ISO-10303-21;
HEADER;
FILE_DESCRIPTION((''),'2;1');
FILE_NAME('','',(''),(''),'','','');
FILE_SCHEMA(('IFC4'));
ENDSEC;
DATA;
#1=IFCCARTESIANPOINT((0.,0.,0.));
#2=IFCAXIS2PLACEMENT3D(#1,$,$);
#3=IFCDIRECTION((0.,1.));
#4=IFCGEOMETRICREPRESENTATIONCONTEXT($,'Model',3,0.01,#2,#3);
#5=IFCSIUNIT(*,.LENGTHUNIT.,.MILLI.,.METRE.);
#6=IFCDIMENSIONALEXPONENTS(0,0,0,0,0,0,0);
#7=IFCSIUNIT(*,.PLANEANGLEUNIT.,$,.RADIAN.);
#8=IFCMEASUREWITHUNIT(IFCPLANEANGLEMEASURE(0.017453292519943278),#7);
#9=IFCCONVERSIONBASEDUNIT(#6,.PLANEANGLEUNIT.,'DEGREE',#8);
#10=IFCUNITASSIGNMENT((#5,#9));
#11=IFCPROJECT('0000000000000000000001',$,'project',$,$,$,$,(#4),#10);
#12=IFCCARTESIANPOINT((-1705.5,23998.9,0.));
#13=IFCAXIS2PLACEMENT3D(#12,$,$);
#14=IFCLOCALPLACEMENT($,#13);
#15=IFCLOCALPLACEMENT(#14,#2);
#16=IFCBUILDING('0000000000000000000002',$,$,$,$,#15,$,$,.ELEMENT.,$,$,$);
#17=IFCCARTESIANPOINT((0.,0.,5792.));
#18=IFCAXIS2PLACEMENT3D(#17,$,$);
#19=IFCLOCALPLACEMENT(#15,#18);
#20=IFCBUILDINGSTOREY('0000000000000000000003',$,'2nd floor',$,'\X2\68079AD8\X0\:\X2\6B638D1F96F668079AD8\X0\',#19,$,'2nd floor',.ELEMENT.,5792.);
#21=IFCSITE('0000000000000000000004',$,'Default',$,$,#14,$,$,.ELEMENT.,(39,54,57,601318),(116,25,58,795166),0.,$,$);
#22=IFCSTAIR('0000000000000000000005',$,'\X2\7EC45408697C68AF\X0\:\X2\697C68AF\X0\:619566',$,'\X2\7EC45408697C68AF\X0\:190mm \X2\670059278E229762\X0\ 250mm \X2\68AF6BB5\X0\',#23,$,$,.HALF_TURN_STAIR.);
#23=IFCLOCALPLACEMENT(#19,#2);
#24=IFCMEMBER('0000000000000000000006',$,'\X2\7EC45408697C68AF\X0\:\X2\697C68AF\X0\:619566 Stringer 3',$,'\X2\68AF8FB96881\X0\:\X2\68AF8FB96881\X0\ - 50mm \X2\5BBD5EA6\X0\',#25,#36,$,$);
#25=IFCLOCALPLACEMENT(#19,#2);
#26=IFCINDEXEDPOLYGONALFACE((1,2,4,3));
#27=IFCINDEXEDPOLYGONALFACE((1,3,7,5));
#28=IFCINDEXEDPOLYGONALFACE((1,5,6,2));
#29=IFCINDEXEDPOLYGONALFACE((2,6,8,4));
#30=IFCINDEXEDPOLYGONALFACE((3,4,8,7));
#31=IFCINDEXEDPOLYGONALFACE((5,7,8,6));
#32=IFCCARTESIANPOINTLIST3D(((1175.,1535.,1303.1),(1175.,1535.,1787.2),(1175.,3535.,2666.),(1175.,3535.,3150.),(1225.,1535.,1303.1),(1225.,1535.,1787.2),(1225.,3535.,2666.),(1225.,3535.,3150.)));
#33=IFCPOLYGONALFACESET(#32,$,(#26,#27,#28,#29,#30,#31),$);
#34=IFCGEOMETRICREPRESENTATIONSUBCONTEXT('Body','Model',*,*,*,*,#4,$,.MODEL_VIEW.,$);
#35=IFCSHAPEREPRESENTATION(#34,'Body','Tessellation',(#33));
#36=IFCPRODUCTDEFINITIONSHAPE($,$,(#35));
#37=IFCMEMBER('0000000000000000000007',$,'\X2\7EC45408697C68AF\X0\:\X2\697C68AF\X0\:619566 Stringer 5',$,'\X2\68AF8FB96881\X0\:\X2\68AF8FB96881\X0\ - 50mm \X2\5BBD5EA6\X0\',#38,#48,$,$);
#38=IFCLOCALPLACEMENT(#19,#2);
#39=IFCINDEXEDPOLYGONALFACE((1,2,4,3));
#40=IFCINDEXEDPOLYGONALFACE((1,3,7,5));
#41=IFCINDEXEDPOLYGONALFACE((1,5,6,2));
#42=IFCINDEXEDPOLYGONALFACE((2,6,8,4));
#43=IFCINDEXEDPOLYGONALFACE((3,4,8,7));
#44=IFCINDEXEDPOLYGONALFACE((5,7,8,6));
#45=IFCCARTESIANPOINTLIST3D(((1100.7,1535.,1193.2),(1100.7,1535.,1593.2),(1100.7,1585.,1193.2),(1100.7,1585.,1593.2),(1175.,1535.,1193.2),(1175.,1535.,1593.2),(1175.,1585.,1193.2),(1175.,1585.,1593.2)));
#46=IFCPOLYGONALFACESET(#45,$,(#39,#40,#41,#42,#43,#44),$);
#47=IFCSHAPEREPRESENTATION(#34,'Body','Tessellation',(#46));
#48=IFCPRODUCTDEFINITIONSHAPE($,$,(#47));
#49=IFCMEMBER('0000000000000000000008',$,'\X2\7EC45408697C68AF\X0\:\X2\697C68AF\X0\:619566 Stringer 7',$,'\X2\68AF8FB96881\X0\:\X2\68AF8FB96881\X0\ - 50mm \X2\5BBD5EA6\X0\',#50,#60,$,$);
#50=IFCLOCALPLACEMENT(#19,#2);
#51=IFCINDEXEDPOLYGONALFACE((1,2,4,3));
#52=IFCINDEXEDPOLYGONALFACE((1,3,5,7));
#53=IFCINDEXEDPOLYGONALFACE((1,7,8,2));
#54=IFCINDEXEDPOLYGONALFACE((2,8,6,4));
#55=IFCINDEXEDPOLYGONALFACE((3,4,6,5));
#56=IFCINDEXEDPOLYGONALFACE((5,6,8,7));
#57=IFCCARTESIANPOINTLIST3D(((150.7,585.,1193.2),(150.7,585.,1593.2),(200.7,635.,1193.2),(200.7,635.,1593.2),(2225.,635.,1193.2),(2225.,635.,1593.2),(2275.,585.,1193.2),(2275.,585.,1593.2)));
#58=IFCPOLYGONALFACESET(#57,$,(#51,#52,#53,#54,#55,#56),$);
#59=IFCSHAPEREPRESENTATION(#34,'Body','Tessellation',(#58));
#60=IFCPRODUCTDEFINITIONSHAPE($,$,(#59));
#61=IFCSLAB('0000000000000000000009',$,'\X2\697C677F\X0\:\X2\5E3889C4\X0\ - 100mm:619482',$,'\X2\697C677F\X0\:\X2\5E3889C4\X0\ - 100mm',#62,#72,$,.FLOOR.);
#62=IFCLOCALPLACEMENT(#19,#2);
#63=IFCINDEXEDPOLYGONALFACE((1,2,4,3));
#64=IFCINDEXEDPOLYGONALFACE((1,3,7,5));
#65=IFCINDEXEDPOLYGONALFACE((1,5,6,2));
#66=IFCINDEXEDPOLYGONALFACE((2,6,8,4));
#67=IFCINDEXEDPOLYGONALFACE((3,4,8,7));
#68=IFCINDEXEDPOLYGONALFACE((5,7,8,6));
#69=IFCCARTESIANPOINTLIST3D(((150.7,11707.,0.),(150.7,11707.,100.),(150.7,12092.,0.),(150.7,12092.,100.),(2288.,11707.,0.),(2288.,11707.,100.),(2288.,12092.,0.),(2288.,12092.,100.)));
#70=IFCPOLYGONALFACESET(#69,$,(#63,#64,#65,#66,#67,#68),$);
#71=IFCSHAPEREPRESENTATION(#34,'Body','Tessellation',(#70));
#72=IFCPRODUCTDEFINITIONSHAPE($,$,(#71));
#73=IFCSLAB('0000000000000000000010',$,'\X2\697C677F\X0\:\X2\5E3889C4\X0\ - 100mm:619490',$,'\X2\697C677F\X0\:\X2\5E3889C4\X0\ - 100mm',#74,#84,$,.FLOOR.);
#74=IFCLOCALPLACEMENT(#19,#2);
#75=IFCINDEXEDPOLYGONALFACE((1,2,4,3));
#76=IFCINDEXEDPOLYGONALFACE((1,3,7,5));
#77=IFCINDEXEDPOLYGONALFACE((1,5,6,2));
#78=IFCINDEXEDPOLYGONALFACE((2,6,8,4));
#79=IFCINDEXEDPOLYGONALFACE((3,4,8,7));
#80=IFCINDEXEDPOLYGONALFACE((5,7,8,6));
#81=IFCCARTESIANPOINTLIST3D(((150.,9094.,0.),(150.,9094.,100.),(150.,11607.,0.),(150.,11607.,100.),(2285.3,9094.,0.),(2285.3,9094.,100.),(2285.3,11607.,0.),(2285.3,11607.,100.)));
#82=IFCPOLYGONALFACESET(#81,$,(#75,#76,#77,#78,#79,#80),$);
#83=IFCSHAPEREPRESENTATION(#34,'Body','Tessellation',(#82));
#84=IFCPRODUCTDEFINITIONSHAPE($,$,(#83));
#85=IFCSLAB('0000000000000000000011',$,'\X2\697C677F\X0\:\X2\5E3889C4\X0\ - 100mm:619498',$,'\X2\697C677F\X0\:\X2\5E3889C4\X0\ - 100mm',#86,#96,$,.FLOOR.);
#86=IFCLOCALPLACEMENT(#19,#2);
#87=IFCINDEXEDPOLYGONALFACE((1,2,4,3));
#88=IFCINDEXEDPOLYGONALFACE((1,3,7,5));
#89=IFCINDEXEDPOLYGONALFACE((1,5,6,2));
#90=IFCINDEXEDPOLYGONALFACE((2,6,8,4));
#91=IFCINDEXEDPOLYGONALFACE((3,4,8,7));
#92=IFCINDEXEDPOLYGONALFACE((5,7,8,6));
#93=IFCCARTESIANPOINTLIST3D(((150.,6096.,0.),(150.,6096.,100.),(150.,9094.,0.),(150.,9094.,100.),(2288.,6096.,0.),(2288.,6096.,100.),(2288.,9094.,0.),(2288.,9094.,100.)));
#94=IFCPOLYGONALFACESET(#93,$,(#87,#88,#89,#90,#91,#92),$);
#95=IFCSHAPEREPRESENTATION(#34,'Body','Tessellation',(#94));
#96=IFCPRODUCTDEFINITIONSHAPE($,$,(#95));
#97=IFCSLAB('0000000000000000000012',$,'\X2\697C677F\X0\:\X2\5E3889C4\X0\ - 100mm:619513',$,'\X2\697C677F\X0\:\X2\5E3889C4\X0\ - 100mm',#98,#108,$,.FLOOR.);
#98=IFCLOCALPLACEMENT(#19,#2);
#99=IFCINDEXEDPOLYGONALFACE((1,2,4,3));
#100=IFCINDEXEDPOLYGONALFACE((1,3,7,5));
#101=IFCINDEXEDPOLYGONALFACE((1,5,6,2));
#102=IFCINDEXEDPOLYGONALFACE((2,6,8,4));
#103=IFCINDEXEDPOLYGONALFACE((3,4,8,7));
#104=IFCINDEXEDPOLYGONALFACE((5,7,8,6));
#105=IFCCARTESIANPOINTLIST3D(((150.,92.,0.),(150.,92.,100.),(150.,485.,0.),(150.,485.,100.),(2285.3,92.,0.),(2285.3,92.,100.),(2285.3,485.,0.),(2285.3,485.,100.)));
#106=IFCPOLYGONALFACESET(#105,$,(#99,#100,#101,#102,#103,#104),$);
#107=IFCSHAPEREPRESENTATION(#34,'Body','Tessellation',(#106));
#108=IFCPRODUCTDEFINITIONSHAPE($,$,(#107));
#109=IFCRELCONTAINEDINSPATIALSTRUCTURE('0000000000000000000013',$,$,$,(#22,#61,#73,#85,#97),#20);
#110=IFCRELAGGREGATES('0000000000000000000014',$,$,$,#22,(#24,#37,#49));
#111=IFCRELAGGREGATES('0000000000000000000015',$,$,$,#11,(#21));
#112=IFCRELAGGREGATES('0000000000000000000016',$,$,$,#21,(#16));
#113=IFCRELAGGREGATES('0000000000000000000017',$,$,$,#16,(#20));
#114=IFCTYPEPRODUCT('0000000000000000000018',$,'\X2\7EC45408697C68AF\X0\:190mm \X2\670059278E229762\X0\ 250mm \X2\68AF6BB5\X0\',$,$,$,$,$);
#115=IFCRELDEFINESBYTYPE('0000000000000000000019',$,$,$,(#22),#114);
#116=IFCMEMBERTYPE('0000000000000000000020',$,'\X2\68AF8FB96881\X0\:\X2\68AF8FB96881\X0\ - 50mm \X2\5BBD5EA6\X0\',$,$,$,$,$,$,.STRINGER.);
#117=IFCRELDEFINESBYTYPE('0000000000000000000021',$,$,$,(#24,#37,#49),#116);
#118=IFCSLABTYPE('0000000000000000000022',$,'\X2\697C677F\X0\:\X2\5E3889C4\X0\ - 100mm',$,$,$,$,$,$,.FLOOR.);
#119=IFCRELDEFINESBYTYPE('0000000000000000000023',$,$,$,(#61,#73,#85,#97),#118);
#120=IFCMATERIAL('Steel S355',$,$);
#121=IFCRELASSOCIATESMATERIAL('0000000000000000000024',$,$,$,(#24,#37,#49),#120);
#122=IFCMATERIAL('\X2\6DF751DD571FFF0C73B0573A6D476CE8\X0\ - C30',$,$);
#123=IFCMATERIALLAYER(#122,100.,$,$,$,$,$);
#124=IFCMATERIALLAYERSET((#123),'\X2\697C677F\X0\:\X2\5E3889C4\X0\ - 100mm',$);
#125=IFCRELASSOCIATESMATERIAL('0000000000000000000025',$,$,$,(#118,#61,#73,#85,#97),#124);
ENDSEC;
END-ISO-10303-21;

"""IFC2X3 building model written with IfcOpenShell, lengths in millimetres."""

from ifc_helpers import new_model, entity, si_unit, converted_unit, direction, frame, frame_2d, origin, origin_2d_with_axis, place, context, subcontext, project, spatial, polyline, rectangle, outline, extrude, material, layer, layer_set, layer_usage, type_object, element, aggregate, save


model = new_model("IFC2X3")

# Units and contexts
model_context = context("Model", 3, precision=0.01, world=origin(), true_north=direction((0.0, 1.0)))
body_context = subcontext(model_context, "Body", "Model", "MODEL_VIEW")
ifc_project = project(units=[si_unit("LENGTHUNIT", "METRE", prefix="MILLI"), converted_unit("PLANEANGLEUNIT", "DEGREE", entity("IfcPlaneAngleMeasure", 0.017453292519943278), si_unit("PLANEANGLEUNIT", "RADIAN"), dimensions=[0, 0, 0, 0, 0, 0, 0])], contexts=[model_context])

# Site, building, storey
site_placement = place(None, frame((-1705.5, 23998.9, 0.0)))
site = spatial("IfcSite", under=ifc_project, at=site_placement, Name="Default", CompositionType="ELEMENT", RefLatitude=(39, 54, 57, 601318), RefLongitude=(116, 25, 58, 795166), RefElevation=0.0)
building_placement = place(site_placement, origin())
building = spatial("IfcBuilding", under=site, at=building_placement, CompositionType="ELEMENT")
storey_placement = place(building_placement, frame((0.0, 0.0, 5792.0)))
storey = spatial("IfcBuildingStorey", under=building, at=storey_placement, Name="2nd floor", ObjectType="标高:正负零标高", LongName="2nd floor", CompositionType="ELEMENT", Elevation=5792.0)

# Stair, members
type_product = type_object("IfcTypeProduct", Name="组合楼梯:190mm 最大踢面 250mm 梯段")
stair_placement = place(storey_placement, origin())
stair = element("IfcStair", 1, at=stair_placement, inside=storey, type_object=type_product, Name="组合楼梯:楼梯:619566", ObjectType="组合楼梯:190mm 最大踢面 250mm 梯段", ShapeType="HALF_TURN_STAIR")
ifc_material_1 = material(Name="Steel S355")
member_type = type_object("IfcMemberType", Name="梯边梁:梯边梁 - 50mm 宽度", PredefinedType="STRINGER")
member_1_placement = place(stair_placement, origin())
member_1 = element("IfcMember", 2, at=member_1_placement, type_object=member_type, material=ifc_material_1, Name="组合楼梯:楼梯:619566 Stringer 3", ObjectType="梯边梁:梯边梁 - 50mm 宽度", context=body_context, shape_type="SweptSolid", body=[
    extrude(outline(polyline([(-1346.4, -200.0), (1073.8, -200.0), (1346.4, 200.0), (-1073.8, 200.0), (-1346.4, -200.0)])), frame((1175.0, 2535.0, 2226.6), z_axis=(1.0, 0.0, 0.0), x_axis=(0.0, 0.826384, 0.563108)), (0.0, 0.0, 1.0), 50.0),
])
member_2_placement = place(stair_placement, origin())
member_2 = element("IfcMember", 3, at=member_2_placement, type_object=member_type, material=ifc_material_1, Name="组合楼梯:楼梯:619566 Stringer 5", ObjectType="梯边梁:梯边梁 - 50mm 宽度", context=body_context, shape_type="SweptSolid", body=[
    extrude(rectangle(XDim=74.3, YDim=50.0, at=origin_2d_with_axis()), frame((1137.8, 1560.0, 1193.2), z_axis=(0.0, 0.0, 1.0), x_axis=(-1.0, 0.0, 0.0)), (0.0, 0.0, 1.0), 400.0),
])
member_3_placement = place(stair_placement, origin())
member_3 = element("IfcMember", 4, at=member_3_placement, type_object=member_type, material=ifc_material_1, Name="组合楼梯:楼梯:619566 Stringer 7", ObjectType="梯边梁:梯边梁 - 50mm 宽度", context=body_context, shape_type="SweptSolid", body=[
    extrude(outline(polyline([(-1062.2, -25.0), (1062.2, -25.0), (1012.2, 25.0), (-1012.2, 25.0), (-1062.2, -25.0)])), frame((1212.8, 610.0, 1193.2)), (0.0, 0.0, 1.0), 400.0),
])

# Slabs
ifc_material_2 = material(Name="混凝土，现场浇注 - C30")
ifc_layer_1 = layer(ifc_material_2, 100.0)
ifc_layer_set_1 = layer_set([ifc_layer_1], Name="楼板:常规 - 100mm")
ifc_layer_usage_1 = layer_usage(ifc_layer_set_1, "AXIS3", "POSITIVE", 0.0)
slab_type_1 = type_object("IfcSlabType", Name="楼板:常规 - 100mm", PredefinedType="FLOOR", material=ifc_layer_set_1)
slab_1_placement = place(storey_placement, origin())
element("IfcSlab", 5, at=slab_1_placement, inside=storey, type_object=slab_type_1, material=ifc_layer_usage_1, Name="楼板:常规 - 100mm:619482", ObjectType="楼板:常规 - 100mm", PredefinedType="FLOOR", context=body_context, shape_type="SweptSolid", body=[
    extrude(rectangle(XDim=385.0, YDim=2137.3, at=origin_2d_with_axis()), frame((1219.3, 11899.5, 100.0), z_axis=(0.0, 0.0, -1.0), x_axis=(0.0, 1.0, 0.0)), (0.0, 0.0, 1.0), 100.0),
])
ifc_layer_usage_2 = layer_usage(ifc_layer_set_1, "AXIS3", "POSITIVE", 0.0)
slab_2_placement = place(storey_placement, origin())
element("IfcSlab", 6, at=slab_2_placement, inside=storey, type_object=slab_type_1, material=ifc_layer_usage_2, Name="楼板:常规 - 100mm:619490", ObjectType="楼板:常规 - 100mm", PredefinedType="FLOOR", context=body_context, shape_type="SweptSolid", body=[
    extrude(rectangle(XDim=2513.0, YDim=2135.3, at=frame_2d((0.0, 0.0), x_axis=(1.0, 0.0))), frame((1217.6, 10350.5, 100.0), z_axis=(0.0, 0.0, -1.0), x_axis=(0.0, 1.0, 0.0)), (0.0, 0.0, 1.0), 100.0),
])
ifc_layer_usage_3 = layer_usage(ifc_layer_set_1, "AXIS3", "POSITIVE", 0.0)
slab_3_placement = place(storey_placement, origin())
element("IfcSlab", 7, at=slab_3_placement, inside=storey, type_object=slab_type_1, material=ifc_layer_usage_3, Name="楼板:常规 - 100mm:619498", ObjectType="楼板:常规 - 100mm", PredefinedType="FLOOR", context=body_context, shape_type="SweptSolid", body=[
    extrude(rectangle(XDim=2998.0, YDim=2138.0, at=origin_2d_with_axis()), frame((1219.0, 7595.0, 100.0), z_axis=(0.0, 0.0, -1.0), x_axis=(0.0, 1.0, 0.0)), (0.0, 0.0, 1.0), 100.0),
])
ifc_layer_usage_4 = layer_usage(ifc_layer_set_1, "AXIS3", "POSITIVE", 0.0)
slab_4_placement = place(storey_placement, origin())
element("IfcSlab", 8, at=slab_4_placement, inside=storey, type_object=slab_type_1, material=ifc_layer_usage_4, Name="楼板:常规 - 100mm:619513", ObjectType="楼板:常规 - 100mm", PredefinedType="FLOOR", context=body_context, shape_type="SweptSolid", body=[
    extrude(rectangle(XDim=393.0, YDim=2135.3, at=frame_2d((0.0, 0.0), x_axis=(1.0, 0.0))), frame((1217.7, 288.5, 100.0), z_axis=(0.0, 0.0, -1.0), x_axis=(0.0, 1.0, 0.0)), (0.0, 0.0, 1.0), 100.0),
])

aggregate(stair, [member_1, member_2, member_3])

save(model, "model.ifc")
